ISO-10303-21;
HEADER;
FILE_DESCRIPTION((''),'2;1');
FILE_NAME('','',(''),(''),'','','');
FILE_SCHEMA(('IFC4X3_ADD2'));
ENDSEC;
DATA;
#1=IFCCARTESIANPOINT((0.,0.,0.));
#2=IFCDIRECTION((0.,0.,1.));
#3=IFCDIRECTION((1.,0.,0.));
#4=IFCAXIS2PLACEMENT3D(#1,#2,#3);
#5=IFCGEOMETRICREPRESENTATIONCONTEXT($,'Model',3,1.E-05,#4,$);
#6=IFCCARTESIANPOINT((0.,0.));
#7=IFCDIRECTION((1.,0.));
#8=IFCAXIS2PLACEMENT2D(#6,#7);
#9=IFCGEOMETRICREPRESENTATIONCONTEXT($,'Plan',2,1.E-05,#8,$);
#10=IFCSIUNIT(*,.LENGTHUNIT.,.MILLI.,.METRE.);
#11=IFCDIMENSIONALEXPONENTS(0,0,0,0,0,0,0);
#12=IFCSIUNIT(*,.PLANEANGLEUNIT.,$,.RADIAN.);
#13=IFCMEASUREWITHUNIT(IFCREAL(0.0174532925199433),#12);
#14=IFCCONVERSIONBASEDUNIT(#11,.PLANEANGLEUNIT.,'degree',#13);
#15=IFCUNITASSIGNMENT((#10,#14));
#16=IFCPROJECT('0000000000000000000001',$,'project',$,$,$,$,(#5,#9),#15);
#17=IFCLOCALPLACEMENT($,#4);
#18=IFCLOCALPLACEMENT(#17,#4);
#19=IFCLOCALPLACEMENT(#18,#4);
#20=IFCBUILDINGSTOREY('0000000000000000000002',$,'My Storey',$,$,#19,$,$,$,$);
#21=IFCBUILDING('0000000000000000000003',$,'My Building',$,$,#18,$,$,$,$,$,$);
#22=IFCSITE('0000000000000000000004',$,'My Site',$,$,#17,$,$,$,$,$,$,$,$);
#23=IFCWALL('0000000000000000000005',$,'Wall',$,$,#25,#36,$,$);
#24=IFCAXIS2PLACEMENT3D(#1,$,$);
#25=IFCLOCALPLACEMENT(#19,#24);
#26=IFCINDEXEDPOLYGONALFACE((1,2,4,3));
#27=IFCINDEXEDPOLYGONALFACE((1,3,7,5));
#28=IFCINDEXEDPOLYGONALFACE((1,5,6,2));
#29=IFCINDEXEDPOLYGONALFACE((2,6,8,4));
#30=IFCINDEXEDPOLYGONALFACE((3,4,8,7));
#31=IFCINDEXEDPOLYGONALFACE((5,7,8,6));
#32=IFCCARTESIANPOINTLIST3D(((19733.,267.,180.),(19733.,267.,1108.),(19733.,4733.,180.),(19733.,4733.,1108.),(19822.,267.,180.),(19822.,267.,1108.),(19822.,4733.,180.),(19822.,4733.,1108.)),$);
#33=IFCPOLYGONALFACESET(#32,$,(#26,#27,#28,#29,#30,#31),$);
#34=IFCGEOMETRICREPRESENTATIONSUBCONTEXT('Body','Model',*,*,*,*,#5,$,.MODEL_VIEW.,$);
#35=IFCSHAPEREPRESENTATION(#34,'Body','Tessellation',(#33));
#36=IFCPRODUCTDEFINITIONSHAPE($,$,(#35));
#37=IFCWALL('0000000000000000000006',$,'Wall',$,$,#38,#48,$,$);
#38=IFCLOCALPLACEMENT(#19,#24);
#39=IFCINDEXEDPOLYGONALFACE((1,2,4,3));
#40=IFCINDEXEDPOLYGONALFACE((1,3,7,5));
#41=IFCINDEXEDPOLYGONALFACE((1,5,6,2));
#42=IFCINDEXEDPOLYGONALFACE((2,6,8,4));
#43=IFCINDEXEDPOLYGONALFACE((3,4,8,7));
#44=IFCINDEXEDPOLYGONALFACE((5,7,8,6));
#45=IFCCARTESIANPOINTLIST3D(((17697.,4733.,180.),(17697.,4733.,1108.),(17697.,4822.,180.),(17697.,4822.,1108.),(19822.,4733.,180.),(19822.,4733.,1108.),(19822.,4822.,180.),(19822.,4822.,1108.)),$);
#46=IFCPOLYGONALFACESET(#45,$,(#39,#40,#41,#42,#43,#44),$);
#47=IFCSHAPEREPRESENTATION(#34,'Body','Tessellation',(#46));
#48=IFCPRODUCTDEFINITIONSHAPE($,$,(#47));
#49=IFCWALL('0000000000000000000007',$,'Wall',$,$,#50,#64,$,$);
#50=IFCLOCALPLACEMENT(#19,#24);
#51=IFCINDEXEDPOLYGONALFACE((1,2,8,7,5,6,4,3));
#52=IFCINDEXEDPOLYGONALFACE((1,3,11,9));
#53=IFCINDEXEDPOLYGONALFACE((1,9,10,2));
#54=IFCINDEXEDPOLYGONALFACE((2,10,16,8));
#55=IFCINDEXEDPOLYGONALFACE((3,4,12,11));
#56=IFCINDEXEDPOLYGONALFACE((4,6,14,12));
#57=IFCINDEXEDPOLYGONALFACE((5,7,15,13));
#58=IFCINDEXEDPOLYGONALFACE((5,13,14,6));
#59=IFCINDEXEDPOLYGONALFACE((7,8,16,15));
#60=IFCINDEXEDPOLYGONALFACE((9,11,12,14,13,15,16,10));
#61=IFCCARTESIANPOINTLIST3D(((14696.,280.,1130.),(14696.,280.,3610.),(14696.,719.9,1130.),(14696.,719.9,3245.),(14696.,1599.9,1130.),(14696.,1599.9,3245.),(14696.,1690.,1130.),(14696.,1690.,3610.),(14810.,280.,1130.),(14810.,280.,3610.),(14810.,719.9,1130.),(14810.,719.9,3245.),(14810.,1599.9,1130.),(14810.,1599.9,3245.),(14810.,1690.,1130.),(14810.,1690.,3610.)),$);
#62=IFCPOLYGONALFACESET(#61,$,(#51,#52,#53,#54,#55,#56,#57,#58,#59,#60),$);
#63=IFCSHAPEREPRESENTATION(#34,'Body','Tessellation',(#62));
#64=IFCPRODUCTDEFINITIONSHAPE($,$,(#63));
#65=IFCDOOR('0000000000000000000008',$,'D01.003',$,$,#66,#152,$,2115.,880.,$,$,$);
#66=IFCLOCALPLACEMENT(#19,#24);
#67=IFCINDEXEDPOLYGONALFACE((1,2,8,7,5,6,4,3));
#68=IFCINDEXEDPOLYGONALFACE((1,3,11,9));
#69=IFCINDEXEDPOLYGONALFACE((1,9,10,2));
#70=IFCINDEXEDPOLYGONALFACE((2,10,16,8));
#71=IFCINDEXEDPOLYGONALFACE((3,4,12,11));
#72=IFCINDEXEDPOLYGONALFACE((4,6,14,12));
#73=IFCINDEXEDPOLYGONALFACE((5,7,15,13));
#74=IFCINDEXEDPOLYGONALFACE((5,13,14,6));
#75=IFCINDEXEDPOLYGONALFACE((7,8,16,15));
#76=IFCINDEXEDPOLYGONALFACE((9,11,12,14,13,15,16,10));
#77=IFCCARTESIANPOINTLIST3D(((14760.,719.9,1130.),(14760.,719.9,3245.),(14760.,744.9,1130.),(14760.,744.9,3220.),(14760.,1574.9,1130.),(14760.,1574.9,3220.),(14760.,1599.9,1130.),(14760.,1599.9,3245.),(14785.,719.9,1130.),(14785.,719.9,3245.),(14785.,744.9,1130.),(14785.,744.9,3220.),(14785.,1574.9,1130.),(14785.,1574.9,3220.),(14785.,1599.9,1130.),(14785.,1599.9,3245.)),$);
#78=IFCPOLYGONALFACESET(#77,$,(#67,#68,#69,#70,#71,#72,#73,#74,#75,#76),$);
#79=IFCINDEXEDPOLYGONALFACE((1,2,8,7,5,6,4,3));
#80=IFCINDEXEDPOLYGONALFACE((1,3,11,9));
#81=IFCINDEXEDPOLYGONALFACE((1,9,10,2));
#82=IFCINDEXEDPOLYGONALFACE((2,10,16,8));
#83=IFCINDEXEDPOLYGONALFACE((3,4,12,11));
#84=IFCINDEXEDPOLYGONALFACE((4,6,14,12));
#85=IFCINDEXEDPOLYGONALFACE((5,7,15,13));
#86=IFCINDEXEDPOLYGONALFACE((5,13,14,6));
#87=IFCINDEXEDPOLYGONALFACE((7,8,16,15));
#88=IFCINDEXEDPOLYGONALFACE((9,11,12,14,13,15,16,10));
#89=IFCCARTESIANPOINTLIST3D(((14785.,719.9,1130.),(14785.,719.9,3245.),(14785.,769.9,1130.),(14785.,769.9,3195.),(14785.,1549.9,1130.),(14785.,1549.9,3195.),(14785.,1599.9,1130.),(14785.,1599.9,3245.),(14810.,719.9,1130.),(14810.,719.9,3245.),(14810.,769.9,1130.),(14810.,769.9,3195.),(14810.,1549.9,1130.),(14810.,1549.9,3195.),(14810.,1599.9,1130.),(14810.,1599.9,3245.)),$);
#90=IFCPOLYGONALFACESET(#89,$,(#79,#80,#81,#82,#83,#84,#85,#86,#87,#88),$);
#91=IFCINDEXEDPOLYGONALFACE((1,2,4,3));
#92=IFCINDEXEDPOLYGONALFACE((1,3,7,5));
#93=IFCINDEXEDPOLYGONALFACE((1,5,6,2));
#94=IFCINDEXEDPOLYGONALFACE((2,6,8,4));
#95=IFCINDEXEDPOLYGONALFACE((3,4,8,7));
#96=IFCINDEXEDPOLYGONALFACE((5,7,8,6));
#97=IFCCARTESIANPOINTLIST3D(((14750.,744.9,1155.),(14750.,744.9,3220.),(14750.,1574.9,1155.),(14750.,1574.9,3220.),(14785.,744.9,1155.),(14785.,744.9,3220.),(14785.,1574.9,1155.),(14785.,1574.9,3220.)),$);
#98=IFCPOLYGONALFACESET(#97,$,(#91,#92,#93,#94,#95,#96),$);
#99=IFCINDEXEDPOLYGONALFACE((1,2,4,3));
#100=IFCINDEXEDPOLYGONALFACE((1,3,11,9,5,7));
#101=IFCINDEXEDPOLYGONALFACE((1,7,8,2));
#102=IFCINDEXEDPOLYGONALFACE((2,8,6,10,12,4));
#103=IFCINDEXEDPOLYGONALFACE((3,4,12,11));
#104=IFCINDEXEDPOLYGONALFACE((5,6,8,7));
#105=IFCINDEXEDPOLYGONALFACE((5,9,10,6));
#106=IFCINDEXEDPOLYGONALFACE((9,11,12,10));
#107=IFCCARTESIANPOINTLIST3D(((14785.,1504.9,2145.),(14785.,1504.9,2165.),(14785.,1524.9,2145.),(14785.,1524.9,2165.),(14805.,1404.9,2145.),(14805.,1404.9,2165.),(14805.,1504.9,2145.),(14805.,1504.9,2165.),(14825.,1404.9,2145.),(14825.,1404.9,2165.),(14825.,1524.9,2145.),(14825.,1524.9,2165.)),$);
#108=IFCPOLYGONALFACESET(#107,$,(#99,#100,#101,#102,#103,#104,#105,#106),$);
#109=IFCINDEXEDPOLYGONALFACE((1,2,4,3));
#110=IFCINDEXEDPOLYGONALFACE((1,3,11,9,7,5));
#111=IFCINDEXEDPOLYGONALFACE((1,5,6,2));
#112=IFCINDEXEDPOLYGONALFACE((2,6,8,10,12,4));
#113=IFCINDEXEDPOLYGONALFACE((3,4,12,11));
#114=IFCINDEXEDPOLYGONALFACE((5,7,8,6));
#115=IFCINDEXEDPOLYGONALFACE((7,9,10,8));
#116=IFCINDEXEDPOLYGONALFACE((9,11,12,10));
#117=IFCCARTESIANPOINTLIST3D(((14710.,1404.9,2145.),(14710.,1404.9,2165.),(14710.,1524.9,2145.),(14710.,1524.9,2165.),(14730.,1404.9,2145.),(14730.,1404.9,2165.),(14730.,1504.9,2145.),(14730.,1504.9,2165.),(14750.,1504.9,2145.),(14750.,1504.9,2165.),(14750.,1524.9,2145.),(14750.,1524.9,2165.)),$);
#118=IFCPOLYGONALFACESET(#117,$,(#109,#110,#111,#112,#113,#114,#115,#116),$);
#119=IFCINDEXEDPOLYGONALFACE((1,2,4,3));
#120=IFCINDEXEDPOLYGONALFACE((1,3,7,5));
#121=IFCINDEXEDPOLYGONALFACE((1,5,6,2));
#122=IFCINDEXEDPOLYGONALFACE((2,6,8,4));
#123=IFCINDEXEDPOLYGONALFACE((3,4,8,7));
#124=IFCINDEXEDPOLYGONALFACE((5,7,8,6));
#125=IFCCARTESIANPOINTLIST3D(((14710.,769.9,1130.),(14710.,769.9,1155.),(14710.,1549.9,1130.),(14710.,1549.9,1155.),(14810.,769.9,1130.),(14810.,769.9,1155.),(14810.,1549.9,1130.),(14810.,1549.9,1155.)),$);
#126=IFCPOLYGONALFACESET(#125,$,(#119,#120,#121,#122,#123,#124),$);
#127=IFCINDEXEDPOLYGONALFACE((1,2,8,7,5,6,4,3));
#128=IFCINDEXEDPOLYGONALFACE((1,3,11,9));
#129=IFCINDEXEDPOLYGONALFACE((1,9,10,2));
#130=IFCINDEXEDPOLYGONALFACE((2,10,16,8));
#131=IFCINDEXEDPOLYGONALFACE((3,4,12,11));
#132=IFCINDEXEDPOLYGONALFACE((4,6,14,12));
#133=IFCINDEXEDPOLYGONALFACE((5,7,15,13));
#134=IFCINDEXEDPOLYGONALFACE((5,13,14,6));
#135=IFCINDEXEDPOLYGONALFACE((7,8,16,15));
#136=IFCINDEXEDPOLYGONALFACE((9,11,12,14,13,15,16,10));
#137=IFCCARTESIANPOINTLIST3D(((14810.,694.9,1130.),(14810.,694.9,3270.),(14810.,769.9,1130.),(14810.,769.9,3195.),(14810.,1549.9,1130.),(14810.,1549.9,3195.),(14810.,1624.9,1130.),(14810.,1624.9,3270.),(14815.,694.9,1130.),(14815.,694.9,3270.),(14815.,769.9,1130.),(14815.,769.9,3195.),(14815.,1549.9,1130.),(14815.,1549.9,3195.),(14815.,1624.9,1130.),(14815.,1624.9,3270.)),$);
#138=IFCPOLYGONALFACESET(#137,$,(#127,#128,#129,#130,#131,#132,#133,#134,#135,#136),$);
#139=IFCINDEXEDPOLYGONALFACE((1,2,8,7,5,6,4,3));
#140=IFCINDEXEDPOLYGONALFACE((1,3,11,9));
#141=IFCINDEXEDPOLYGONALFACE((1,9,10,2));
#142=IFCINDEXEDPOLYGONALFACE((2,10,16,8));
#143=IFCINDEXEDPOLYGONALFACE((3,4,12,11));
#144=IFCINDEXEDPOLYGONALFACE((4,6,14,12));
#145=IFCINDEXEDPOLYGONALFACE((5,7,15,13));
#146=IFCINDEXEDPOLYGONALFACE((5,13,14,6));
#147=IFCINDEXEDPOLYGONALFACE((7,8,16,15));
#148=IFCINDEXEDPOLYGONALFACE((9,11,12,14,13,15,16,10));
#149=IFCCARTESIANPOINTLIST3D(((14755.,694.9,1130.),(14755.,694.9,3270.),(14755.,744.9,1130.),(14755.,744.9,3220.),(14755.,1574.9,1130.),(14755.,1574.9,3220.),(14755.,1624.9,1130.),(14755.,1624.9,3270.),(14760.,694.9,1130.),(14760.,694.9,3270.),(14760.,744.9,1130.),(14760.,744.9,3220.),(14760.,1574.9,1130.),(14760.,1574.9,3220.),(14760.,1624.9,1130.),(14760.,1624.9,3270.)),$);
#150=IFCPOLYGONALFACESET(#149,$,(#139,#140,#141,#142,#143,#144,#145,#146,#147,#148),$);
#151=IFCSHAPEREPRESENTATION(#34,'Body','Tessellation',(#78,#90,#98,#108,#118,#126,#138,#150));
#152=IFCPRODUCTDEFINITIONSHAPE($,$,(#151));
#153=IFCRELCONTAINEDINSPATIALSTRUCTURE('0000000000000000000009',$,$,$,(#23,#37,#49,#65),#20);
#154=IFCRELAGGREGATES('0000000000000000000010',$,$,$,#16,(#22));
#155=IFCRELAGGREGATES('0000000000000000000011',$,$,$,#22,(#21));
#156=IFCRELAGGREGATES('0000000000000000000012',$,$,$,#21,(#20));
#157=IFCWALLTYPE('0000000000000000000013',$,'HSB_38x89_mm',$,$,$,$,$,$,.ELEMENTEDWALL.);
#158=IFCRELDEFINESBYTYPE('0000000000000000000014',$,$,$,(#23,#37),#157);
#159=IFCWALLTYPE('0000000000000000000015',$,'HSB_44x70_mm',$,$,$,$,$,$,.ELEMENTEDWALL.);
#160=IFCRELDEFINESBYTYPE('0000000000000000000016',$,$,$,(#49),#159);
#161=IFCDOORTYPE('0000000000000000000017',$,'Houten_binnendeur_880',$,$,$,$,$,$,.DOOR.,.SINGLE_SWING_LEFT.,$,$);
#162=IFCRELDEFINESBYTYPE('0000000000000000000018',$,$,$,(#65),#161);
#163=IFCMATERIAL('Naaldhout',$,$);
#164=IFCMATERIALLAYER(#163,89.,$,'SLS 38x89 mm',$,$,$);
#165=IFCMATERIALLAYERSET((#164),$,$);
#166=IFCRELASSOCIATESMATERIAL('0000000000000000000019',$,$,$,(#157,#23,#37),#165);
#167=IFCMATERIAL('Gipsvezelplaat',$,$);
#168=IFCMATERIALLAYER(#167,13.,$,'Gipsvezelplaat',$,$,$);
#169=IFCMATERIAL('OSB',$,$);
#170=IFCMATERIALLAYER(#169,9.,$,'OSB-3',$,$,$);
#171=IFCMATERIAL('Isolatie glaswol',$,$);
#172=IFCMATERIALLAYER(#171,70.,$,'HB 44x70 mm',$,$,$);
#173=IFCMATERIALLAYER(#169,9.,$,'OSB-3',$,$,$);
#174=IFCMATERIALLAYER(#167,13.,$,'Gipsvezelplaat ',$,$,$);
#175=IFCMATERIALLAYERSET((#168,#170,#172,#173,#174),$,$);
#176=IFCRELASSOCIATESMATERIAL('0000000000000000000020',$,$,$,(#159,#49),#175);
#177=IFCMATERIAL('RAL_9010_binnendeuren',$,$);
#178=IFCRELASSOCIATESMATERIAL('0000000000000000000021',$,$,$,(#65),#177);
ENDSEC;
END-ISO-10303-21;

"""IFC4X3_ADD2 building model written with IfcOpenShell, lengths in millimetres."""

from ifc_helpers import new_model, entity, si_unit, converted_unit, frame, origin_with_axes, origin_2d_with_axis, place, context, subcontext, project, spatial, line, indexed_curve, outline, extrude, shape, source, transform, mapped, material, layer, layer_set, layer_usage, type_object, type_shapes, element, fill, save


model = new_model("IFC4X3_ADD2")

# Units and contexts
model_context = context("Model", 3, precision=1e-05, world=origin_with_axes())
plan_context = context("Plan", 2, precision=1e-05, world=origin_2d_with_axis())
body_context_1 = subcontext(model_context, "Body", "Model", "MODEL_VIEW")
body_context_2 = subcontext(plan_context, "Body", "Plan", "PLAN_VIEW")
ifc_project = project(units=[si_unit("LENGTHUNIT", "METRE", prefix="MILLI"), converted_unit("PLANEANGLEUNIT", "degree", entity("IfcReal", 0.0174532925199433), si_unit("PLANEANGLEUNIT", "RADIAN"), dimensions=[0, 0, 0, 0, 0, 0, 0])], contexts=[model_context, plan_context])

# Site, building, storey
site_placement = place(None, origin_with_axes())
site = spatial("IfcSite", under=ifc_project, at=site_placement, Name="My Site")
building_placement = place(site_placement, origin_with_axes())
building = spatial("IfcBuilding", under=site, at=building_placement, Name="My Building")
storey_placement = place(building_placement, origin_with_axes())
storey = spatial("IfcBuildingStorey", under=building, at=storey_placement, Name="My Storey")

# Shared definitions
ifc_material_1 = material(Name="Isolatie glaswol")

# Shared definitions
ifc_material_2 = material(Name="OSB")
ifc_material_3 = material(Name="Gipsvezelplaat")

# Walls
ifc_material_4 = material(Name="Naaldhout")
ifc_layer_1 = layer(ifc_material_4, 89.0, Name="SLS 38x89 mm")
ifc_layer_set_1 = layer_set([ifc_layer_1])
wall_type_1 = type_object("IfcWallType", Name="HSB_38x89_mm", PredefinedType="ELEMENTEDWALL", material=ifc_layer_set_1)
ifc_layer_usage_1 = layer_usage(ifc_layer_set_1, "AXIS2", "POSITIVE", 0.0)
wall_1_placement = place(storey_placement, frame((19733.0, 4733.0, 180.0), z_axis=(0.0, 0.0, 1.0), x_axis=(0.0, -1.0, 0.0)))
element("IfcWall", 1, at=wall_1_placement, inside=storey, type_object=wall_type_1, material=ifc_layer_usage_1, Name="Wall", context=body_context_1, shape_type="SweptSolid", body=[
    extrude(outline(indexed_curve([(0.0, 0.0), (0.0, 89.0), (4466.0, 89.0), (4466.0, 0.0), (0.0, 0.0)], self_intersect=False)), origin_with_axes(), (0.0, 0.0, 1.0), 928.0),
])
ifc_layer_usage_2 = layer_usage(ifc_layer_set_1, "AXIS2", "POSITIVE", 0.0)
wall_2_placement = place(storey_placement, frame((17697.0, 4733.0, 180.0), z_axis=(0.0, 0.0, 1.0), x_axis=(1.0, 0.0, 0.0)))
element("IfcWall", 2, at=wall_2_placement, inside=storey, type_object=wall_type_1, material=ifc_layer_usage_2, Name="Wall", context=body_context_1, shape_type="SweptSolid", body=[
    extrude(outline(indexed_curve([(0.0, 0.0), (0.0, 89.0), (2125.0, 89.0), (2125.0, 0.0), (0.0, 0.0)], self_intersect=False)), origin_with_axes(), (0.0, 0.0, 1.0), 928.0),
])

# Wall, opening, door
ifc_layer_2 = layer(ifc_material_3, 13.0, Name="Gipsvezelplaat")
ifc_layer_3 = layer(ifc_material_2, 9.0, Name="OSB-3")
ifc_layer_4 = layer(ifc_material_1, 70.0, Name="HB 44x70 mm")
ifc_layer_5 = layer(ifc_material_2, 9.0, Name="OSB-3")
ifc_layer_6 = layer(ifc_material_3, 13.0, Name="Gipsvezelplaat ")
ifc_layer_set_2 = layer_set([ifc_layer_2, ifc_layer_3, ifc_layer_4, ifc_layer_5, ifc_layer_6])
ifc_layer_usage_3 = layer_usage(ifc_layer_set_2, "AXIS2", "POSITIVE", 0.0)
wall_type_2 = type_object("IfcWallType", Name="HSB_44x70_mm", PredefinedType="ELEMENTEDWALL", material=ifc_layer_set_2)
wall_3_placement = place(storey_placement, frame((14810.0, 280.0, 1130.0), z_axis=(0.0, 0.0, 1.0), x_axis=(0.0, 1.0, 0.0)))
wall_3 = element("IfcWall", 3, at=wall_3_placement, inside=storey, type_object=wall_type_2, material=ifc_layer_usage_3, Name="Wall", context=body_context_1, shape_type="SweptSolid", body=[
    extrude(outline(indexed_curve([(0.0, 0.0), (0.0, 114.0), (1410.0, 114.0), (1410.0, 0.0), (0.0, 0.0)], self_intersect=False)), origin_with_axes(), (0.0, 0.0, 1.0), 2480.0),
])
shared_shape_1 = source(origin_with_axes(), body_context_1, "Body", "SweptSolid", [
    extrude(outline(indexed_curve([(0.0, 0.0), (880.0, 0.0), (880.0, 2115.0), (0.0, 2115.0)], segments=[line(1, 2, 3, 4, 1)])), frame((0.0, -600.0, 0.0), z_axis=(0.0, -1.0, 0.0), x_axis=(1.0, 0.0, 0.0)), (0.0, 0.0, -1.0), 1200.0),
])
opening_1_placement = place(wall_3_placement, frame((439.9, 0.0, 0.0), z_axis=(0.0, 0.0, 1.0), x_axis=(1.0, 0.0, 0.0)))
opening_1 = element("IfcOpeningElement", 4, at=opening_1_placement, cuts=wall_3, PredefinedType="OPENING", context=body_context_1, shape_type="MappedRepresentation", body=[
    mapped(shared_shape_1, transform((0.0, 0.0, 0.0), x_axis=(1.0, 0.0, 0.0), y_axis=(0.0, 1.0, 0.0), z_axis=(0.0, 0.0, 1.0), scale=1.0)),
])
ifc_material_5 = material(Name="RAL_9010_binnendeuren")
door_type_1 = type_object("IfcDoorType", Name="Houten_binnendeur_880", OperationType="SINGLE_SWING_LEFT", PredefinedType="DOOR")
shared_shape_2 = source(origin_with_axes(), body_context_1, "Body", "SweptSolid", [
    extrude(outline(indexed_curve([(0.0, 0.0), (0.0, 2115.0), (880.0, 2115.0), (880.0, 0.0), (855.0, 0.0), (855.0, 2090.0), (25.0, 2090.0), (25.0, 0.0)], segments=[line(1, 2, 3, 4, 5, 6, 7, 8, 1)])), frame((0.0, 25.0, 0.0), z_axis=(0.0, -1.0, 0.0), x_axis=(1.0, 0.0, 0.0)), (0.0, 0.0, -1.0), 25.0),
    extrude(outline(indexed_curve([(0.0, 0.0), (0.0, 2115.0), (880.0, 2115.0), (880.0, 0.0), (830.0, 0.0), (830.0, 2065.0), (50.0, 2065.0), (50.0, 0.0)], segments=[line(1, 2, 3, 4, 5, 6, 7, 8, 1)])), frame((0.0, 0.0, 0.0), z_axis=(0.0, -1.0, 0.0), x_axis=(1.0, 0.0, 0.0)), (0.0, 0.0, -1.0), 25.0),
    extrude(outline(indexed_curve([(0.0, 0.0), (830.0, 0.0), (830.0, 35.0), (0.0, 35.0)], segments=[line(1, 2, 3, 4, 1)])), frame((25.0, 25.0, 25.0), z_axis=(0.0, 0.0, 1.0), x_axis=(1.0, 0.0, 0.0)), (0.0, 0.0, 1.0), 2065.0),
    extrude(outline(indexed_curve([(0.0, 0.0), (0.0, -40.0), (-120.0, -40.0), (-120.0, -20.0), (-20.0, -20.0), (-20.0, 0.0)], segments=[line(1, 2, 3, 4, 5, 6, 1)])), frame((805.0, 25.0, 1015.0), z_axis=(0.0, 0.0, 1.0), x_axis=(1.0, 0.0, 0.0)), (0.0, 0.0, 1.0), 20.0),
    extrude(outline(indexed_curve([(0.0, 0.0), (0.0, 40.0), (-120.0, 40.0), (-120.0, 20.0), (-20.0, 20.0), (-20.0, 0.0)], segments=[line(1, 2, 3, 4, 5, 6, 1)])), frame((805.0, 60.0, 1015.0), z_axis=(0.0, 0.0, 1.0), x_axis=(1.0, 0.0, 0.0)), (0.0, 0.0, 1.0), 20.0),
    extrude(outline(indexed_curve([(0.0, 0.0), (780.0, 0.0), (780.0, 100.0), (0.0, 100.0)], segments=[line(1, 2, 3, 4, 1)])), frame((50.0, 0.0, 0.0), z_axis=(0.0, 0.0, 1.0), x_axis=(1.0, 0.0, 0.0)), (0.0, 0.0, 1.0), 25.0),
    extrude(outline(indexed_curve([(0.0, 0.0), (0.0, 2140.0), (930.0, 2140.0), (930.0, 0.0), (855.0, 0.0), (855.0, 2065.0), (75.0, 2065.0), (75.0, 0.0)], segments=[line(1, 2, 3, 4, 5, 6, 7, 8, 1)])), frame((-25.0, -5.0, 0.0), z_axis=(0.0, -1.0, 0.0), x_axis=(1.0, 0.0, 0.0)), (0.0, 0.0, -1.0), 5.0),
    extrude(outline(indexed_curve([(0.0, 0.0), (0.0, 2140.0), (930.0, 2140.0), (930.0, 0.0), (880.0, 0.0), (880.0, 2090.0), (50.0, 2090.0), (50.0, 0.0)], segments=[line(1, 2, 3, 4, 5, 6, 7, 8, 1)])), frame((-25.0, 50.0, 0.0), z_axis=(0.0, -1.0, 0.0), x_axis=(1.0, 0.0, 0.0)), (0.0, 0.0, -1.0), 5.0),
])
shared_shape_3 = source(origin_with_axes(), body_context_2, "Body", "Curve2D", [
    entity("IfcIndexedPolyCurve", entity("IfcCartesianPointList2D", [[0.0, 0.0], [0.0, 50.0], [25.0, 50.0], [25.0, 25.0], [50.0, 25.0], [50.0, 0.0]]), [entity("IfcLineIndex", [1, 2, 3, 4, 5, 6, 1])]),
    entity("IfcIndexedPolyCurve", entity("IfcCartesianPointList2D", [[880.0, 0.0], [880.0, 50.0], [855.0, 50.0], [855.0, 25.0], [830.0, 25.0], [830.0, 0.0]]), [entity("IfcLineIndex", [1, 2, 3, 4, 5, 6, 1])]),
    entity("IfcTrimmedCurve", entity("IfcEllipse", entity("IfcAxis2Placement2D", entity("IfcCartesianPoint", [60.0, 50.0]), entity("IfcDirection", [1.0, 0.0])), 795.0, 830.0), [entity("IfcCartesianPoint", [855.0, 50.0])], [entity("IfcCartesianPoint", [60.0, 880.0])], True, "CARTESIAN"),
    entity("IfcIndexedPolyCurve", entity("IfcCartesianPointList2D", [[25.0, 50.0], [60.0, 50.0], [60.0, 880.0], [25.0, 880.0]]), [entity("IfcLineIndex", [1, 2, 3, 4, 1])]),
])
type_shapes(door_type_1, [shared_shape_2, shared_shape_3])
door_1_placement = place(opening_1_placement, frame((0.0, 0.0, 0.0), z_axis=(0.0, 0.0, 1.0), x_axis=(1.0, 0.0, 0.0)))
door_1 = element("IfcDoor", 5, at=door_1_placement, inside=storey, type_object=door_type_1, material=ifc_material_5, Name="D01.003", OverallHeight=2115.0, OverallWidth=880.0, shapes=[
    shape(body_context_1, "Body", "MappedRepresentation", [mapped(shared_shape_2, transform((0.0, 0.0, 0.0), x_axis=(1.0, 0.0, 0.0), y_axis=(0.0, 1.0, 0.0), z_axis=(0.0, 0.0, 1.0), scale=1.0))]),
    shape(body_context_2, "Body", "MappedRepresentation", [mapped(shared_shape_3, transform((0.0, 0.0, 0.0), x_axis=(1.0, 0.0, 0.0), y_axis=(0.0, 1.0, 0.0), z_axis=(0.0, 0.0, 1.0), scale=1.0))]),
])
fill(opening_1, door_1)

save(model, "model.ifc")
